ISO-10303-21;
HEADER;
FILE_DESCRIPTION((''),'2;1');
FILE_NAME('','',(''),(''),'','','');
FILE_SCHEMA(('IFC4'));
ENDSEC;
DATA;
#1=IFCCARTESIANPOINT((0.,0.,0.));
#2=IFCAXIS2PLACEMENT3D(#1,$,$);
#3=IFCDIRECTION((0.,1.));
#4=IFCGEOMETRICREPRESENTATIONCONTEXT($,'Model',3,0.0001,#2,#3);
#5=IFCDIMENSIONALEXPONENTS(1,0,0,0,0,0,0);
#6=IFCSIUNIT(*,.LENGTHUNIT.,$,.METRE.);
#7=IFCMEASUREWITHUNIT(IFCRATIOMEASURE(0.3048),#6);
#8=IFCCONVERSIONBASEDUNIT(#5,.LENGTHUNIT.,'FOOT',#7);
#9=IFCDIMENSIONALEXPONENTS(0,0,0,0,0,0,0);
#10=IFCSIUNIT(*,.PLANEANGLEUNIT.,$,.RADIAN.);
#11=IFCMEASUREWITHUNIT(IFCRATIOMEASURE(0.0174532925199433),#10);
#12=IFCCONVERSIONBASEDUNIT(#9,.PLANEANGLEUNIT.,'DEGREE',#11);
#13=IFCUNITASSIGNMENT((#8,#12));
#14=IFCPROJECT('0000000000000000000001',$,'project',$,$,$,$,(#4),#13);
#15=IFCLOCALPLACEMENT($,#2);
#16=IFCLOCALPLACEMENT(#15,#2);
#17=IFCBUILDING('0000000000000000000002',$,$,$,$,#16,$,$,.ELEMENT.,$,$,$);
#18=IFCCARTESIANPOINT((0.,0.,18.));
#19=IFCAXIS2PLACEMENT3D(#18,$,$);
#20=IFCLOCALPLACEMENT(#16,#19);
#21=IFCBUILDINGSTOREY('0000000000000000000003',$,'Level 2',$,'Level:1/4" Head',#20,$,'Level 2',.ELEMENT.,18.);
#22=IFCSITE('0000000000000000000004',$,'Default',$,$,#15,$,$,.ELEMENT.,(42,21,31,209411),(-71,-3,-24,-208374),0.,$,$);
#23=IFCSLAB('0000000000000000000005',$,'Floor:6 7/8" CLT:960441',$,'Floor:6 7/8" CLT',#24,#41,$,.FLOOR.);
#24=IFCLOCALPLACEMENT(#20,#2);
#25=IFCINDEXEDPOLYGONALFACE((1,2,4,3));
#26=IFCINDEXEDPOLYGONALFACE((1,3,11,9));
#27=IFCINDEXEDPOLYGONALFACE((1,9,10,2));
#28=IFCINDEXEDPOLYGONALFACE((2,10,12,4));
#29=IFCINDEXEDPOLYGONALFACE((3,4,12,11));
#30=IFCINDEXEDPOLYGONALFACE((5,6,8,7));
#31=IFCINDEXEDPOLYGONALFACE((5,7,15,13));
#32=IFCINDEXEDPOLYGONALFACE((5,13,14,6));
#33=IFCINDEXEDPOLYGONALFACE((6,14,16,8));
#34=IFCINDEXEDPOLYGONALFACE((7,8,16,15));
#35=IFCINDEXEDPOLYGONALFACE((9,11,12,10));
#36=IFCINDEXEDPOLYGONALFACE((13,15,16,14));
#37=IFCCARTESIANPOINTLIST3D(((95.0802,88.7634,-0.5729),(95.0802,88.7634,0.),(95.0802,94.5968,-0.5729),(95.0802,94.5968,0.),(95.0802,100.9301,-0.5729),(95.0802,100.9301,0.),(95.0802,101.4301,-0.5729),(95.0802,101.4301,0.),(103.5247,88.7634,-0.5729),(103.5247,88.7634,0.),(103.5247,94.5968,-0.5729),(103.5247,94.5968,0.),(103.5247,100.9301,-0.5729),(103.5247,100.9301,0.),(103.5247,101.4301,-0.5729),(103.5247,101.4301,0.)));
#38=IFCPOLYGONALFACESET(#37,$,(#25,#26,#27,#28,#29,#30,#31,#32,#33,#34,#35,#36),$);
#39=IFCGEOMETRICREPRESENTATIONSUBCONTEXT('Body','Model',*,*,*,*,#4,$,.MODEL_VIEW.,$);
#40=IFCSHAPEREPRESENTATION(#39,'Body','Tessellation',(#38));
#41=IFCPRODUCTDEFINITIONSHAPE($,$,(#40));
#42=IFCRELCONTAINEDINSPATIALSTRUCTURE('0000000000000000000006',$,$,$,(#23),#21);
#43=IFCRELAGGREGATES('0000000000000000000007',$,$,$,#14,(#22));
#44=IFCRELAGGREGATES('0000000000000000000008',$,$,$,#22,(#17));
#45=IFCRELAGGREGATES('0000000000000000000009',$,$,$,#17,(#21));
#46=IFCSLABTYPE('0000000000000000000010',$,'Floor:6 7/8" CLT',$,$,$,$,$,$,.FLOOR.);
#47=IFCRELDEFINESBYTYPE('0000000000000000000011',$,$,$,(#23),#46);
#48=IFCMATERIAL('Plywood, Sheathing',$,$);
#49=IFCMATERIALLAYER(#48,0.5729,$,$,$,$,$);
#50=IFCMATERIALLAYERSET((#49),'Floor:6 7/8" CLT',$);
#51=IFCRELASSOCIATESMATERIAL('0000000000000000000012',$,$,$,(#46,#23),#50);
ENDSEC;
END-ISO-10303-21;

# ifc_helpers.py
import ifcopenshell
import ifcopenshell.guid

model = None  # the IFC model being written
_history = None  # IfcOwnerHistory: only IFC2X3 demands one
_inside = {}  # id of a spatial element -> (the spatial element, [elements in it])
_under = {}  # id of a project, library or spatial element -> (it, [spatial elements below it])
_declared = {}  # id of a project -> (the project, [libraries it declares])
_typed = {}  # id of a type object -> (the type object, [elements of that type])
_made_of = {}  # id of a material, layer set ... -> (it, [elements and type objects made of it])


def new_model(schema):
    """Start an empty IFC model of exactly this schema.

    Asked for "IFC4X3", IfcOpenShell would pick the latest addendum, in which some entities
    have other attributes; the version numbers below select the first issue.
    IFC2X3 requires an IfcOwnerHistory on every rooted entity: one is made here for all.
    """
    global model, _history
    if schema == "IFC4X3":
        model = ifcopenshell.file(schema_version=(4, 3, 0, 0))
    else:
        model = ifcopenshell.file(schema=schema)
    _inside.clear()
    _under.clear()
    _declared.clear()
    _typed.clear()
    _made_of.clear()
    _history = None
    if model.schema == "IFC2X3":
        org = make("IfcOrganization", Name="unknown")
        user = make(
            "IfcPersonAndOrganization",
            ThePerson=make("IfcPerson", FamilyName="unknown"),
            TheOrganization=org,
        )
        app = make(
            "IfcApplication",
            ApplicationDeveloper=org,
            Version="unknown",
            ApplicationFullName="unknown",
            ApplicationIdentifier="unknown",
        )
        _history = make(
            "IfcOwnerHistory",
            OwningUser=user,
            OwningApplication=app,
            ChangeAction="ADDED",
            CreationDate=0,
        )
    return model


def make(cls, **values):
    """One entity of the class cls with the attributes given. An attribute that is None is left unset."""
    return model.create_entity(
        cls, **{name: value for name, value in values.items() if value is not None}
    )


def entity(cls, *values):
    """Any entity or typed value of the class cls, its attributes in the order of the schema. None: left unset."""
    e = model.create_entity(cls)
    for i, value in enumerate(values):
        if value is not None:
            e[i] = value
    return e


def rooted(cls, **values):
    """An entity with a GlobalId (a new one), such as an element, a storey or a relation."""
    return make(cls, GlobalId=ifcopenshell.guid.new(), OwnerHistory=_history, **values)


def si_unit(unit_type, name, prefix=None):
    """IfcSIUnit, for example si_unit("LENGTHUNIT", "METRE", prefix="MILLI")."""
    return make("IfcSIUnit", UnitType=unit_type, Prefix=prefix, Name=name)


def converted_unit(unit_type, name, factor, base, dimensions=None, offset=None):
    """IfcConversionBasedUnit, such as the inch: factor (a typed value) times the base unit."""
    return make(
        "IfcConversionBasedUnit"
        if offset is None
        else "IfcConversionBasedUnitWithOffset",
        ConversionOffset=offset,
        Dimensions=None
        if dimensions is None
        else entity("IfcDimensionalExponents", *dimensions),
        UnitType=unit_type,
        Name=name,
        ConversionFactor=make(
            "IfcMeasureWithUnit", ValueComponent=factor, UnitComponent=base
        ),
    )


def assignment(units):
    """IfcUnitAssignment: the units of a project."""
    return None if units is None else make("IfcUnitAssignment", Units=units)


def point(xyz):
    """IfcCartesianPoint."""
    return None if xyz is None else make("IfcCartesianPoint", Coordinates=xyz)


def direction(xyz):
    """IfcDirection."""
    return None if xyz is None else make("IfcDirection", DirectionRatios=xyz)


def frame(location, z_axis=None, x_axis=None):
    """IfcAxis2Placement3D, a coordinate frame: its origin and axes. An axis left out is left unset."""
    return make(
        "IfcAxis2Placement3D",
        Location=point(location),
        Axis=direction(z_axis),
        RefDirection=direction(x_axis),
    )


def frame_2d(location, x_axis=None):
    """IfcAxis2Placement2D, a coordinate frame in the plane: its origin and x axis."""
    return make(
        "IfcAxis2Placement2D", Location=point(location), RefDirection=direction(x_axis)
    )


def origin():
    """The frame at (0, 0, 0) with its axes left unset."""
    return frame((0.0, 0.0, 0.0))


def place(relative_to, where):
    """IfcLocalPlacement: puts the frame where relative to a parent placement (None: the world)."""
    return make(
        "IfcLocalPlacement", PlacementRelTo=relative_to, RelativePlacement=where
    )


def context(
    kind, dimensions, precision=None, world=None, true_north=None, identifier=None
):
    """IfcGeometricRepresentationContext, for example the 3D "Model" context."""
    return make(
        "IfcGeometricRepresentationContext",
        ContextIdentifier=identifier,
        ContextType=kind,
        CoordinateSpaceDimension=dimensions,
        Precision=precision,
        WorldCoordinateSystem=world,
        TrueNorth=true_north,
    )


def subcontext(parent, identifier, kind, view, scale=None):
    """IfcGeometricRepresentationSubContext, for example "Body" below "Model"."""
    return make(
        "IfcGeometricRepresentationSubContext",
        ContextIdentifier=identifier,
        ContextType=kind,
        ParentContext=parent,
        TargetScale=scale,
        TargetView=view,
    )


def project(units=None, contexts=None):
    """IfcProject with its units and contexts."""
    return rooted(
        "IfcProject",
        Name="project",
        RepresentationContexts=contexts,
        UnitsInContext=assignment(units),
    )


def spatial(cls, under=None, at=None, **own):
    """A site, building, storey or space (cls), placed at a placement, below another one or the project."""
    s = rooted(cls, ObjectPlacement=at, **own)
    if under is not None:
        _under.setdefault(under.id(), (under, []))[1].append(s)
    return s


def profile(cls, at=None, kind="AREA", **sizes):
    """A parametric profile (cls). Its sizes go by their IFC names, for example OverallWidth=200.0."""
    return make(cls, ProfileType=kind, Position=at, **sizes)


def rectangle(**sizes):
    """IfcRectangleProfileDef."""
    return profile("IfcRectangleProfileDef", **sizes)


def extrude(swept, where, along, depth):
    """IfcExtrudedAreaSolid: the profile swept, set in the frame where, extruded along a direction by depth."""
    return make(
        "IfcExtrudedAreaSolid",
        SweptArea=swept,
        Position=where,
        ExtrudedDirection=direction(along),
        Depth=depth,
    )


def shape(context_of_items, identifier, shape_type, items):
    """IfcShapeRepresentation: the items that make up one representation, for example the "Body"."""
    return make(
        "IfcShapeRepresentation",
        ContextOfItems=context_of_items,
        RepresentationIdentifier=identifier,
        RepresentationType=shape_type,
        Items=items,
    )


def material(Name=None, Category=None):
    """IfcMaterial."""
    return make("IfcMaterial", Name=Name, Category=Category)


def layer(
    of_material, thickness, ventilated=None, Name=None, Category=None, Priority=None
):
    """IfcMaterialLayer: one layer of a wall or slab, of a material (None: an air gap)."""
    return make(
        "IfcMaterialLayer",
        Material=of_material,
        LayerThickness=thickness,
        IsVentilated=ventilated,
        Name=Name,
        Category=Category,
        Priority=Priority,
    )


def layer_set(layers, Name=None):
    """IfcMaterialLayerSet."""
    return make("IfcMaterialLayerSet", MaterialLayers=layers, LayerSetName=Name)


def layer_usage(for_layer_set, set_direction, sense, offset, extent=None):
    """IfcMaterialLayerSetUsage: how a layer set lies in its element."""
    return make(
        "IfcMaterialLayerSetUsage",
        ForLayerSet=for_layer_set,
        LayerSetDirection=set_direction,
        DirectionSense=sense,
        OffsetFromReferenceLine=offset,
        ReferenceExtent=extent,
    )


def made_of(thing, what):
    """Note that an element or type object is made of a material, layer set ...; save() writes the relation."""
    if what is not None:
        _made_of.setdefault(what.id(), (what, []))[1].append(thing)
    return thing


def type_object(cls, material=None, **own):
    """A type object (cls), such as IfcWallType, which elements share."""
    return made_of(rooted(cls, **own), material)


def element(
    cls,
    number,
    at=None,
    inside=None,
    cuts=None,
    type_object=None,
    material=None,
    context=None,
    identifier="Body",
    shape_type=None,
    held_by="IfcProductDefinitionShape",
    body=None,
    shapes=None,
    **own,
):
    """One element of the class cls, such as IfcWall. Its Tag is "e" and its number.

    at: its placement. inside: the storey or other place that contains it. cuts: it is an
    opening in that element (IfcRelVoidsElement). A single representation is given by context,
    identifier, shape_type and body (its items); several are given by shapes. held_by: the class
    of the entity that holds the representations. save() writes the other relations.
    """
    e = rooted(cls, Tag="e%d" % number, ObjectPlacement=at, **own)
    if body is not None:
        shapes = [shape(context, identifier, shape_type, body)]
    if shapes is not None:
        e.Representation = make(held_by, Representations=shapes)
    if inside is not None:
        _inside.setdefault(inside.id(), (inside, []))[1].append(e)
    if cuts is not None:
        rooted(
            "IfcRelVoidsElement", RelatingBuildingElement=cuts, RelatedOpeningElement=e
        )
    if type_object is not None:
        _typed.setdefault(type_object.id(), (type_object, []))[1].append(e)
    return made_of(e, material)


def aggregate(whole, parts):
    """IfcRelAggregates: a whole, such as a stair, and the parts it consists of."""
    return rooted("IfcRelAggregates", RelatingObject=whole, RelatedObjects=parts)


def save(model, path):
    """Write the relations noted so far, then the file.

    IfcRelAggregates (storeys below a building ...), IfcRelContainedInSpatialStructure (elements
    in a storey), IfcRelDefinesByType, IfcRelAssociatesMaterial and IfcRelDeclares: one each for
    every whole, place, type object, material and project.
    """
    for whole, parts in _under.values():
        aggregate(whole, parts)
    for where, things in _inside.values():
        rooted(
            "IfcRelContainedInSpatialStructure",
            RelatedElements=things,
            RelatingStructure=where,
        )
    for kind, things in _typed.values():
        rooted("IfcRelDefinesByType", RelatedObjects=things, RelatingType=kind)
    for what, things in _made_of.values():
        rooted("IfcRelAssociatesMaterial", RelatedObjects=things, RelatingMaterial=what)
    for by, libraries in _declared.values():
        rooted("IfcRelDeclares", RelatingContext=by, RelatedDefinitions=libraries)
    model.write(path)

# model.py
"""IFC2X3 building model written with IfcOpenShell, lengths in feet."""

from ifc_helpers import new_model, entity, si_unit, converted_unit, direction, frame, frame_2d, origin, place, context, subcontext, project, spatial, rectangle, extrude, material, layer, layer_set, layer_usage, type_object, element, save


model = new_model("IFC2X3")

# Units and contexts
model_context = context("Model", 3, precision=0.0001, world=origin(), true_north=direction((0.0, 1.0)))
body_context = subcontext(model_context, "Body", "Model", "MODEL_VIEW")
ifc_project = project(units=[converted_unit("LENGTHUNIT", "FOOT", entity("IfcRatioMeasure", 0.3048), si_unit("LENGTHUNIT", "METRE"), dimensions=[1, 0, 0, 0, 0, 0, 0]), converted_unit("PLANEANGLEUNIT", "DEGREE", entity("IfcRatioMeasure", 0.0174532925199433), si_unit("PLANEANGLEUNIT", "RADIAN"), dimensions=[0, 0, 0, 0, 0, 0, 0])], contexts=[model_context])

# Site, building, storey
site_placement = place(None, origin())
site = spatial("IfcSite", under=ifc_project, at=site_placement, Name="Default", CompositionType="ELEMENT", RefLatitude=(42, 21, 31, 209411), RefLongitude=(-71, -3, -24, -208374), RefElevation=0.0)
building_placement = place(site_placement, origin())
building = spatial("IfcBuilding", under=site, at=building_placement, CompositionType="ELEMENT")
storey_placement = place(building_placement, frame((0.0, 0.0, 18.0)))
storey = spatial("IfcBuildingStorey", under=building, at=storey_placement, Name="Level 2", ObjectType="Level:1/4\" Head", LongName="Level 2", CompositionType="ELEMENT", Elevation=18.0)

# Slab, opening
ifc_material_1 = material(Name="Plywood, Sheathing")
ifc_layer = layer(ifc_material_1, 0.5729)
ifc_layer_set = layer_set([ifc_layer], Name="Floor:6 7/8\" CLT")
ifc_layer_usage = layer_usage(ifc_layer_set, "AXIS3", "POSITIVE", 0.0)
slab_type = type_object("IfcSlabType", Name="Floor:6 7/8\" CLT", PredefinedType="FLOOR", material=ifc_layer_set)
slab_placement = place(storey_placement, frame((95.0802, 88.7634, -0.5729)))
slab = element("IfcSlab", 1, at=slab_placement, inside=storey, type_object=slab_type, material=ifc_layer_usage, Name="Floor:6 7/8\" CLT:960441", ObjectType="Floor:6 7/8\" CLT", PredefinedType="FLOOR", context=body_context, shape_type="SweptSolid", body=[
    extrude(rectangle(XDim=12.6667, YDim=8.4444, at=frame_2d((0.0, 0.0), x_axis=(0.0, -1.0))), frame((4.2222, 6.3333, 0.5729), z_axis=(0.0, 0.0, -1.0), x_axis=(-1.0, 0.0, 0.0)), (0.0, 0.0, 1.0), 0.5729),
])
opening_placement = place(storey_placement, frame((95.0802, 88.7634, -0.5729)))
element("IfcOpeningElement", 2, at=opening_placement, cuts=slab, ObjectType="Opening", context=body_context, shape_type="SweptSolid", body=[
    extrude(rectangle(XDim=6.3333, YDim=24.3333, at=frame_2d((-0.0196, 2.6667), x_axis=(0.0, -1.0))), frame((4.2222, 6.3333, 0.5729), z_axis=(0.0, 0.0, -1.0), x_axis=(-1.0, 0.0, 0.0)), (0.0, 0.0, 1.0), 0.5729),
])

save(model, "model.ifc")
